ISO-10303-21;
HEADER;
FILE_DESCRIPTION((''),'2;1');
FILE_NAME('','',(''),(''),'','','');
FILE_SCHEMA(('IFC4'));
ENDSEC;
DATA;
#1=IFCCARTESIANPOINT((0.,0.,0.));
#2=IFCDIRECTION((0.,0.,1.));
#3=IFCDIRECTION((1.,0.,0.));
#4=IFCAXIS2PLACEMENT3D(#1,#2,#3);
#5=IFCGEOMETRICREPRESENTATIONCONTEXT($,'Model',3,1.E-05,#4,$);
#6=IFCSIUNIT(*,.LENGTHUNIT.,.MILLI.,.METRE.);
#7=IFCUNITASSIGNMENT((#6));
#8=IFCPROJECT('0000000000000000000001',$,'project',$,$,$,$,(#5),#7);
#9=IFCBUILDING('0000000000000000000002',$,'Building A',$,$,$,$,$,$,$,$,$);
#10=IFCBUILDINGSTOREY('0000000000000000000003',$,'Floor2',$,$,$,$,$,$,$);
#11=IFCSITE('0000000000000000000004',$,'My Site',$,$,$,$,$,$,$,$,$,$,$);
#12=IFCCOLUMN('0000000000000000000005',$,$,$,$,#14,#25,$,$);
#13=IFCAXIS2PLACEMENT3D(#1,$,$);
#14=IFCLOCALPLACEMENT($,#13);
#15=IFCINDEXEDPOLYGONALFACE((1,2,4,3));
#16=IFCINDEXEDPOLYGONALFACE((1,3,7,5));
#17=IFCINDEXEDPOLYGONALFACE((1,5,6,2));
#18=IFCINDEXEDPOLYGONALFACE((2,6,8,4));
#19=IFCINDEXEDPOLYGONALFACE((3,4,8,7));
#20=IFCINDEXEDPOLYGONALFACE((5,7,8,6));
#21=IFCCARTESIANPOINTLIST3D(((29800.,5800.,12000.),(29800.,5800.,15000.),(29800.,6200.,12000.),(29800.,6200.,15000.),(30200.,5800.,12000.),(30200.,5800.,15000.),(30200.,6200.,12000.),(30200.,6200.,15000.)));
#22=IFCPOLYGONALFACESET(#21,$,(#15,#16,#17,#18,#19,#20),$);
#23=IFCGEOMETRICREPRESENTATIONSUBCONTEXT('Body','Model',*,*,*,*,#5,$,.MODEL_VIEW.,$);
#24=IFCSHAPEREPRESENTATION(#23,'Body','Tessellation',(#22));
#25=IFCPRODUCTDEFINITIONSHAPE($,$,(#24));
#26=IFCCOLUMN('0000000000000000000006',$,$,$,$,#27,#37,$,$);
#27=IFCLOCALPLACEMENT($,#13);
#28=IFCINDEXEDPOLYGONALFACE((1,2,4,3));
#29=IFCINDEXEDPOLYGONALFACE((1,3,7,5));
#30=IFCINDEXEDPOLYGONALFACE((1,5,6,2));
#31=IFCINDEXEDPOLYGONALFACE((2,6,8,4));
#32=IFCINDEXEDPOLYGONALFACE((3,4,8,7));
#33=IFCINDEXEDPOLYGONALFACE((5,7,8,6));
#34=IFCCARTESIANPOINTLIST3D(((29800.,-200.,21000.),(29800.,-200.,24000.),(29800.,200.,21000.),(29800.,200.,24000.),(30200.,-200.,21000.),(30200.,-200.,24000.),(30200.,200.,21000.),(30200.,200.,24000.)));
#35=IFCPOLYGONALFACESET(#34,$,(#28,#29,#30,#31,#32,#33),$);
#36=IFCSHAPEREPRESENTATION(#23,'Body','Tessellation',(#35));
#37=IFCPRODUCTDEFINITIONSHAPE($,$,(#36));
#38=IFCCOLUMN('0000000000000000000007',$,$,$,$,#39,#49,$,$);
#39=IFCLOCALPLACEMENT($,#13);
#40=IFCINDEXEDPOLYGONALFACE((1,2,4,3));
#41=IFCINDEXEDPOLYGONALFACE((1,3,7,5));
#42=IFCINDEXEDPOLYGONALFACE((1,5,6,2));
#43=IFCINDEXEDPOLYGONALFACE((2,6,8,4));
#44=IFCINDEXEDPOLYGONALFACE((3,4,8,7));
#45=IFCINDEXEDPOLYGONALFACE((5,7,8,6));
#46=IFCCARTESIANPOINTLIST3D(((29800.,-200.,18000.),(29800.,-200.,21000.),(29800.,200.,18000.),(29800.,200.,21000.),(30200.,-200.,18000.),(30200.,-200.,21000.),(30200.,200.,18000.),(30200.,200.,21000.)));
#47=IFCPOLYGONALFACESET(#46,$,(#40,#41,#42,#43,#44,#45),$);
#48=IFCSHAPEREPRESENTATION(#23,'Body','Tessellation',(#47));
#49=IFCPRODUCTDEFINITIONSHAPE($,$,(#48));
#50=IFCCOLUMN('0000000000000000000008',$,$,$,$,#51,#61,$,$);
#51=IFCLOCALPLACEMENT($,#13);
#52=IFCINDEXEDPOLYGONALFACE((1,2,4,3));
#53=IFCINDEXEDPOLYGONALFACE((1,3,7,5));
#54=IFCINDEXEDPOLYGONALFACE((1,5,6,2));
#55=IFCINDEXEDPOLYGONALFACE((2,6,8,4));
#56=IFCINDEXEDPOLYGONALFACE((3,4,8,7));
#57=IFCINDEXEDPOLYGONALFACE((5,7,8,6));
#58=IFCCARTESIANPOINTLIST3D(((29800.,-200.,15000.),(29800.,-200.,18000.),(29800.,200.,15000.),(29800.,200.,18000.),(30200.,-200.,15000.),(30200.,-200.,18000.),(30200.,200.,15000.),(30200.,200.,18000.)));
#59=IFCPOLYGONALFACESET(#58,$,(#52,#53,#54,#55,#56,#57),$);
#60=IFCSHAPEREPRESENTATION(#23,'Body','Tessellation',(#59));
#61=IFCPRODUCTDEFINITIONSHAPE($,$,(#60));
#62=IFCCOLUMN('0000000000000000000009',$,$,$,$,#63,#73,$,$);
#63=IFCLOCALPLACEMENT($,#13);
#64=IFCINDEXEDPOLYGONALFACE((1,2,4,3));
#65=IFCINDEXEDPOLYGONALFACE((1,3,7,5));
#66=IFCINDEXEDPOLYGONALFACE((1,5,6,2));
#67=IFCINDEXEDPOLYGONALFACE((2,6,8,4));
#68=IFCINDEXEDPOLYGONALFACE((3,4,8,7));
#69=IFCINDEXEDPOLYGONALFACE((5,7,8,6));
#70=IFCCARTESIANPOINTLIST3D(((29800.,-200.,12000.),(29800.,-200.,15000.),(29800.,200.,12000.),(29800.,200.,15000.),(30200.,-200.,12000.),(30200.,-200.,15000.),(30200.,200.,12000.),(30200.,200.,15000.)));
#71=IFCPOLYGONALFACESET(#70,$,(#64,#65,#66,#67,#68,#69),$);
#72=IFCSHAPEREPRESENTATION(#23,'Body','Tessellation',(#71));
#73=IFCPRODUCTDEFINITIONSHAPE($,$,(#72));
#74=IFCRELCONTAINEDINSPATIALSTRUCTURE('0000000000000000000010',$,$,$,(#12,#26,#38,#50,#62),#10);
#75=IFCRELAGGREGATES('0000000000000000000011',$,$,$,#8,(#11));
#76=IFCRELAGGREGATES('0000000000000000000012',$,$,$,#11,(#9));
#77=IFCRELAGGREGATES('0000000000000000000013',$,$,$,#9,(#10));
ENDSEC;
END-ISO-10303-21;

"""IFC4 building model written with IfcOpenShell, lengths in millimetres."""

from ifc_helpers import new_model, si_unit, frame, origin_with_axes, place, context, subcontext, project, spatial, line, indexed_curve, outline, extrude, element, save


model = new_model("IFC4")

# Units and contexts
model_context = context("Model", 3, precision=1e-05, world=origin_with_axes())
body_context = subcontext(model_context, "Body", "Model", "MODEL_VIEW")
ifc_project = project(units=[si_unit("LENGTHUNIT", "METRE", prefix="MILLI")], contexts=[model_context])

# Site, building, storey
site = spatial("IfcSite", under=ifc_project, Name="My Site")
building = spatial("IfcBuilding", under=site, Name="Building A")
storey = spatial("IfcBuildingStorey", under=building, Name="Floor2")

# Columns
for number, where, z_axis, x_axis in (
    (1, (30000.0, 6000.0, 12000.0), (0.0, 0.0, 1.0), (1.0, 0.0, 0.0)),
    (2, (30000.0, 0.0, 21000.0), (0.0, 0.0, 1.0), (1.0, 0.0, 0.0)),
    (3, (30000.0, 0.0, 18000.0), (0.0, 0.0, 1.0), (1.0, 0.0, 0.0)),
    (4, (30000.0, 0.0, 15000.0), (0.0, 0.0, 1.0), (1.0, 0.0, 0.0)),
    (5, (30000.0, 0.0, 12000.0), (0.0, 0.0, 1.0), (1.0, 0.0, 0.0)),
):
    element("IfcColumn", number, at=place(None, frame(where, z_axis=z_axis, x_axis=x_axis)), inside=storey, context=body_context, shape_type="SweptSolid", body=[
        extrude(outline(indexed_curve([(-200.0, -200.0), (200.0, -200.0), (200.0, 200.0), (-200.0, 200.0)], segments=[line(1, 2, 3, 4, 1)])), origin_with_axes(), (0.0, 0.0, 1.0), 3000.0),
    ])

save(model, "model.ifc")
